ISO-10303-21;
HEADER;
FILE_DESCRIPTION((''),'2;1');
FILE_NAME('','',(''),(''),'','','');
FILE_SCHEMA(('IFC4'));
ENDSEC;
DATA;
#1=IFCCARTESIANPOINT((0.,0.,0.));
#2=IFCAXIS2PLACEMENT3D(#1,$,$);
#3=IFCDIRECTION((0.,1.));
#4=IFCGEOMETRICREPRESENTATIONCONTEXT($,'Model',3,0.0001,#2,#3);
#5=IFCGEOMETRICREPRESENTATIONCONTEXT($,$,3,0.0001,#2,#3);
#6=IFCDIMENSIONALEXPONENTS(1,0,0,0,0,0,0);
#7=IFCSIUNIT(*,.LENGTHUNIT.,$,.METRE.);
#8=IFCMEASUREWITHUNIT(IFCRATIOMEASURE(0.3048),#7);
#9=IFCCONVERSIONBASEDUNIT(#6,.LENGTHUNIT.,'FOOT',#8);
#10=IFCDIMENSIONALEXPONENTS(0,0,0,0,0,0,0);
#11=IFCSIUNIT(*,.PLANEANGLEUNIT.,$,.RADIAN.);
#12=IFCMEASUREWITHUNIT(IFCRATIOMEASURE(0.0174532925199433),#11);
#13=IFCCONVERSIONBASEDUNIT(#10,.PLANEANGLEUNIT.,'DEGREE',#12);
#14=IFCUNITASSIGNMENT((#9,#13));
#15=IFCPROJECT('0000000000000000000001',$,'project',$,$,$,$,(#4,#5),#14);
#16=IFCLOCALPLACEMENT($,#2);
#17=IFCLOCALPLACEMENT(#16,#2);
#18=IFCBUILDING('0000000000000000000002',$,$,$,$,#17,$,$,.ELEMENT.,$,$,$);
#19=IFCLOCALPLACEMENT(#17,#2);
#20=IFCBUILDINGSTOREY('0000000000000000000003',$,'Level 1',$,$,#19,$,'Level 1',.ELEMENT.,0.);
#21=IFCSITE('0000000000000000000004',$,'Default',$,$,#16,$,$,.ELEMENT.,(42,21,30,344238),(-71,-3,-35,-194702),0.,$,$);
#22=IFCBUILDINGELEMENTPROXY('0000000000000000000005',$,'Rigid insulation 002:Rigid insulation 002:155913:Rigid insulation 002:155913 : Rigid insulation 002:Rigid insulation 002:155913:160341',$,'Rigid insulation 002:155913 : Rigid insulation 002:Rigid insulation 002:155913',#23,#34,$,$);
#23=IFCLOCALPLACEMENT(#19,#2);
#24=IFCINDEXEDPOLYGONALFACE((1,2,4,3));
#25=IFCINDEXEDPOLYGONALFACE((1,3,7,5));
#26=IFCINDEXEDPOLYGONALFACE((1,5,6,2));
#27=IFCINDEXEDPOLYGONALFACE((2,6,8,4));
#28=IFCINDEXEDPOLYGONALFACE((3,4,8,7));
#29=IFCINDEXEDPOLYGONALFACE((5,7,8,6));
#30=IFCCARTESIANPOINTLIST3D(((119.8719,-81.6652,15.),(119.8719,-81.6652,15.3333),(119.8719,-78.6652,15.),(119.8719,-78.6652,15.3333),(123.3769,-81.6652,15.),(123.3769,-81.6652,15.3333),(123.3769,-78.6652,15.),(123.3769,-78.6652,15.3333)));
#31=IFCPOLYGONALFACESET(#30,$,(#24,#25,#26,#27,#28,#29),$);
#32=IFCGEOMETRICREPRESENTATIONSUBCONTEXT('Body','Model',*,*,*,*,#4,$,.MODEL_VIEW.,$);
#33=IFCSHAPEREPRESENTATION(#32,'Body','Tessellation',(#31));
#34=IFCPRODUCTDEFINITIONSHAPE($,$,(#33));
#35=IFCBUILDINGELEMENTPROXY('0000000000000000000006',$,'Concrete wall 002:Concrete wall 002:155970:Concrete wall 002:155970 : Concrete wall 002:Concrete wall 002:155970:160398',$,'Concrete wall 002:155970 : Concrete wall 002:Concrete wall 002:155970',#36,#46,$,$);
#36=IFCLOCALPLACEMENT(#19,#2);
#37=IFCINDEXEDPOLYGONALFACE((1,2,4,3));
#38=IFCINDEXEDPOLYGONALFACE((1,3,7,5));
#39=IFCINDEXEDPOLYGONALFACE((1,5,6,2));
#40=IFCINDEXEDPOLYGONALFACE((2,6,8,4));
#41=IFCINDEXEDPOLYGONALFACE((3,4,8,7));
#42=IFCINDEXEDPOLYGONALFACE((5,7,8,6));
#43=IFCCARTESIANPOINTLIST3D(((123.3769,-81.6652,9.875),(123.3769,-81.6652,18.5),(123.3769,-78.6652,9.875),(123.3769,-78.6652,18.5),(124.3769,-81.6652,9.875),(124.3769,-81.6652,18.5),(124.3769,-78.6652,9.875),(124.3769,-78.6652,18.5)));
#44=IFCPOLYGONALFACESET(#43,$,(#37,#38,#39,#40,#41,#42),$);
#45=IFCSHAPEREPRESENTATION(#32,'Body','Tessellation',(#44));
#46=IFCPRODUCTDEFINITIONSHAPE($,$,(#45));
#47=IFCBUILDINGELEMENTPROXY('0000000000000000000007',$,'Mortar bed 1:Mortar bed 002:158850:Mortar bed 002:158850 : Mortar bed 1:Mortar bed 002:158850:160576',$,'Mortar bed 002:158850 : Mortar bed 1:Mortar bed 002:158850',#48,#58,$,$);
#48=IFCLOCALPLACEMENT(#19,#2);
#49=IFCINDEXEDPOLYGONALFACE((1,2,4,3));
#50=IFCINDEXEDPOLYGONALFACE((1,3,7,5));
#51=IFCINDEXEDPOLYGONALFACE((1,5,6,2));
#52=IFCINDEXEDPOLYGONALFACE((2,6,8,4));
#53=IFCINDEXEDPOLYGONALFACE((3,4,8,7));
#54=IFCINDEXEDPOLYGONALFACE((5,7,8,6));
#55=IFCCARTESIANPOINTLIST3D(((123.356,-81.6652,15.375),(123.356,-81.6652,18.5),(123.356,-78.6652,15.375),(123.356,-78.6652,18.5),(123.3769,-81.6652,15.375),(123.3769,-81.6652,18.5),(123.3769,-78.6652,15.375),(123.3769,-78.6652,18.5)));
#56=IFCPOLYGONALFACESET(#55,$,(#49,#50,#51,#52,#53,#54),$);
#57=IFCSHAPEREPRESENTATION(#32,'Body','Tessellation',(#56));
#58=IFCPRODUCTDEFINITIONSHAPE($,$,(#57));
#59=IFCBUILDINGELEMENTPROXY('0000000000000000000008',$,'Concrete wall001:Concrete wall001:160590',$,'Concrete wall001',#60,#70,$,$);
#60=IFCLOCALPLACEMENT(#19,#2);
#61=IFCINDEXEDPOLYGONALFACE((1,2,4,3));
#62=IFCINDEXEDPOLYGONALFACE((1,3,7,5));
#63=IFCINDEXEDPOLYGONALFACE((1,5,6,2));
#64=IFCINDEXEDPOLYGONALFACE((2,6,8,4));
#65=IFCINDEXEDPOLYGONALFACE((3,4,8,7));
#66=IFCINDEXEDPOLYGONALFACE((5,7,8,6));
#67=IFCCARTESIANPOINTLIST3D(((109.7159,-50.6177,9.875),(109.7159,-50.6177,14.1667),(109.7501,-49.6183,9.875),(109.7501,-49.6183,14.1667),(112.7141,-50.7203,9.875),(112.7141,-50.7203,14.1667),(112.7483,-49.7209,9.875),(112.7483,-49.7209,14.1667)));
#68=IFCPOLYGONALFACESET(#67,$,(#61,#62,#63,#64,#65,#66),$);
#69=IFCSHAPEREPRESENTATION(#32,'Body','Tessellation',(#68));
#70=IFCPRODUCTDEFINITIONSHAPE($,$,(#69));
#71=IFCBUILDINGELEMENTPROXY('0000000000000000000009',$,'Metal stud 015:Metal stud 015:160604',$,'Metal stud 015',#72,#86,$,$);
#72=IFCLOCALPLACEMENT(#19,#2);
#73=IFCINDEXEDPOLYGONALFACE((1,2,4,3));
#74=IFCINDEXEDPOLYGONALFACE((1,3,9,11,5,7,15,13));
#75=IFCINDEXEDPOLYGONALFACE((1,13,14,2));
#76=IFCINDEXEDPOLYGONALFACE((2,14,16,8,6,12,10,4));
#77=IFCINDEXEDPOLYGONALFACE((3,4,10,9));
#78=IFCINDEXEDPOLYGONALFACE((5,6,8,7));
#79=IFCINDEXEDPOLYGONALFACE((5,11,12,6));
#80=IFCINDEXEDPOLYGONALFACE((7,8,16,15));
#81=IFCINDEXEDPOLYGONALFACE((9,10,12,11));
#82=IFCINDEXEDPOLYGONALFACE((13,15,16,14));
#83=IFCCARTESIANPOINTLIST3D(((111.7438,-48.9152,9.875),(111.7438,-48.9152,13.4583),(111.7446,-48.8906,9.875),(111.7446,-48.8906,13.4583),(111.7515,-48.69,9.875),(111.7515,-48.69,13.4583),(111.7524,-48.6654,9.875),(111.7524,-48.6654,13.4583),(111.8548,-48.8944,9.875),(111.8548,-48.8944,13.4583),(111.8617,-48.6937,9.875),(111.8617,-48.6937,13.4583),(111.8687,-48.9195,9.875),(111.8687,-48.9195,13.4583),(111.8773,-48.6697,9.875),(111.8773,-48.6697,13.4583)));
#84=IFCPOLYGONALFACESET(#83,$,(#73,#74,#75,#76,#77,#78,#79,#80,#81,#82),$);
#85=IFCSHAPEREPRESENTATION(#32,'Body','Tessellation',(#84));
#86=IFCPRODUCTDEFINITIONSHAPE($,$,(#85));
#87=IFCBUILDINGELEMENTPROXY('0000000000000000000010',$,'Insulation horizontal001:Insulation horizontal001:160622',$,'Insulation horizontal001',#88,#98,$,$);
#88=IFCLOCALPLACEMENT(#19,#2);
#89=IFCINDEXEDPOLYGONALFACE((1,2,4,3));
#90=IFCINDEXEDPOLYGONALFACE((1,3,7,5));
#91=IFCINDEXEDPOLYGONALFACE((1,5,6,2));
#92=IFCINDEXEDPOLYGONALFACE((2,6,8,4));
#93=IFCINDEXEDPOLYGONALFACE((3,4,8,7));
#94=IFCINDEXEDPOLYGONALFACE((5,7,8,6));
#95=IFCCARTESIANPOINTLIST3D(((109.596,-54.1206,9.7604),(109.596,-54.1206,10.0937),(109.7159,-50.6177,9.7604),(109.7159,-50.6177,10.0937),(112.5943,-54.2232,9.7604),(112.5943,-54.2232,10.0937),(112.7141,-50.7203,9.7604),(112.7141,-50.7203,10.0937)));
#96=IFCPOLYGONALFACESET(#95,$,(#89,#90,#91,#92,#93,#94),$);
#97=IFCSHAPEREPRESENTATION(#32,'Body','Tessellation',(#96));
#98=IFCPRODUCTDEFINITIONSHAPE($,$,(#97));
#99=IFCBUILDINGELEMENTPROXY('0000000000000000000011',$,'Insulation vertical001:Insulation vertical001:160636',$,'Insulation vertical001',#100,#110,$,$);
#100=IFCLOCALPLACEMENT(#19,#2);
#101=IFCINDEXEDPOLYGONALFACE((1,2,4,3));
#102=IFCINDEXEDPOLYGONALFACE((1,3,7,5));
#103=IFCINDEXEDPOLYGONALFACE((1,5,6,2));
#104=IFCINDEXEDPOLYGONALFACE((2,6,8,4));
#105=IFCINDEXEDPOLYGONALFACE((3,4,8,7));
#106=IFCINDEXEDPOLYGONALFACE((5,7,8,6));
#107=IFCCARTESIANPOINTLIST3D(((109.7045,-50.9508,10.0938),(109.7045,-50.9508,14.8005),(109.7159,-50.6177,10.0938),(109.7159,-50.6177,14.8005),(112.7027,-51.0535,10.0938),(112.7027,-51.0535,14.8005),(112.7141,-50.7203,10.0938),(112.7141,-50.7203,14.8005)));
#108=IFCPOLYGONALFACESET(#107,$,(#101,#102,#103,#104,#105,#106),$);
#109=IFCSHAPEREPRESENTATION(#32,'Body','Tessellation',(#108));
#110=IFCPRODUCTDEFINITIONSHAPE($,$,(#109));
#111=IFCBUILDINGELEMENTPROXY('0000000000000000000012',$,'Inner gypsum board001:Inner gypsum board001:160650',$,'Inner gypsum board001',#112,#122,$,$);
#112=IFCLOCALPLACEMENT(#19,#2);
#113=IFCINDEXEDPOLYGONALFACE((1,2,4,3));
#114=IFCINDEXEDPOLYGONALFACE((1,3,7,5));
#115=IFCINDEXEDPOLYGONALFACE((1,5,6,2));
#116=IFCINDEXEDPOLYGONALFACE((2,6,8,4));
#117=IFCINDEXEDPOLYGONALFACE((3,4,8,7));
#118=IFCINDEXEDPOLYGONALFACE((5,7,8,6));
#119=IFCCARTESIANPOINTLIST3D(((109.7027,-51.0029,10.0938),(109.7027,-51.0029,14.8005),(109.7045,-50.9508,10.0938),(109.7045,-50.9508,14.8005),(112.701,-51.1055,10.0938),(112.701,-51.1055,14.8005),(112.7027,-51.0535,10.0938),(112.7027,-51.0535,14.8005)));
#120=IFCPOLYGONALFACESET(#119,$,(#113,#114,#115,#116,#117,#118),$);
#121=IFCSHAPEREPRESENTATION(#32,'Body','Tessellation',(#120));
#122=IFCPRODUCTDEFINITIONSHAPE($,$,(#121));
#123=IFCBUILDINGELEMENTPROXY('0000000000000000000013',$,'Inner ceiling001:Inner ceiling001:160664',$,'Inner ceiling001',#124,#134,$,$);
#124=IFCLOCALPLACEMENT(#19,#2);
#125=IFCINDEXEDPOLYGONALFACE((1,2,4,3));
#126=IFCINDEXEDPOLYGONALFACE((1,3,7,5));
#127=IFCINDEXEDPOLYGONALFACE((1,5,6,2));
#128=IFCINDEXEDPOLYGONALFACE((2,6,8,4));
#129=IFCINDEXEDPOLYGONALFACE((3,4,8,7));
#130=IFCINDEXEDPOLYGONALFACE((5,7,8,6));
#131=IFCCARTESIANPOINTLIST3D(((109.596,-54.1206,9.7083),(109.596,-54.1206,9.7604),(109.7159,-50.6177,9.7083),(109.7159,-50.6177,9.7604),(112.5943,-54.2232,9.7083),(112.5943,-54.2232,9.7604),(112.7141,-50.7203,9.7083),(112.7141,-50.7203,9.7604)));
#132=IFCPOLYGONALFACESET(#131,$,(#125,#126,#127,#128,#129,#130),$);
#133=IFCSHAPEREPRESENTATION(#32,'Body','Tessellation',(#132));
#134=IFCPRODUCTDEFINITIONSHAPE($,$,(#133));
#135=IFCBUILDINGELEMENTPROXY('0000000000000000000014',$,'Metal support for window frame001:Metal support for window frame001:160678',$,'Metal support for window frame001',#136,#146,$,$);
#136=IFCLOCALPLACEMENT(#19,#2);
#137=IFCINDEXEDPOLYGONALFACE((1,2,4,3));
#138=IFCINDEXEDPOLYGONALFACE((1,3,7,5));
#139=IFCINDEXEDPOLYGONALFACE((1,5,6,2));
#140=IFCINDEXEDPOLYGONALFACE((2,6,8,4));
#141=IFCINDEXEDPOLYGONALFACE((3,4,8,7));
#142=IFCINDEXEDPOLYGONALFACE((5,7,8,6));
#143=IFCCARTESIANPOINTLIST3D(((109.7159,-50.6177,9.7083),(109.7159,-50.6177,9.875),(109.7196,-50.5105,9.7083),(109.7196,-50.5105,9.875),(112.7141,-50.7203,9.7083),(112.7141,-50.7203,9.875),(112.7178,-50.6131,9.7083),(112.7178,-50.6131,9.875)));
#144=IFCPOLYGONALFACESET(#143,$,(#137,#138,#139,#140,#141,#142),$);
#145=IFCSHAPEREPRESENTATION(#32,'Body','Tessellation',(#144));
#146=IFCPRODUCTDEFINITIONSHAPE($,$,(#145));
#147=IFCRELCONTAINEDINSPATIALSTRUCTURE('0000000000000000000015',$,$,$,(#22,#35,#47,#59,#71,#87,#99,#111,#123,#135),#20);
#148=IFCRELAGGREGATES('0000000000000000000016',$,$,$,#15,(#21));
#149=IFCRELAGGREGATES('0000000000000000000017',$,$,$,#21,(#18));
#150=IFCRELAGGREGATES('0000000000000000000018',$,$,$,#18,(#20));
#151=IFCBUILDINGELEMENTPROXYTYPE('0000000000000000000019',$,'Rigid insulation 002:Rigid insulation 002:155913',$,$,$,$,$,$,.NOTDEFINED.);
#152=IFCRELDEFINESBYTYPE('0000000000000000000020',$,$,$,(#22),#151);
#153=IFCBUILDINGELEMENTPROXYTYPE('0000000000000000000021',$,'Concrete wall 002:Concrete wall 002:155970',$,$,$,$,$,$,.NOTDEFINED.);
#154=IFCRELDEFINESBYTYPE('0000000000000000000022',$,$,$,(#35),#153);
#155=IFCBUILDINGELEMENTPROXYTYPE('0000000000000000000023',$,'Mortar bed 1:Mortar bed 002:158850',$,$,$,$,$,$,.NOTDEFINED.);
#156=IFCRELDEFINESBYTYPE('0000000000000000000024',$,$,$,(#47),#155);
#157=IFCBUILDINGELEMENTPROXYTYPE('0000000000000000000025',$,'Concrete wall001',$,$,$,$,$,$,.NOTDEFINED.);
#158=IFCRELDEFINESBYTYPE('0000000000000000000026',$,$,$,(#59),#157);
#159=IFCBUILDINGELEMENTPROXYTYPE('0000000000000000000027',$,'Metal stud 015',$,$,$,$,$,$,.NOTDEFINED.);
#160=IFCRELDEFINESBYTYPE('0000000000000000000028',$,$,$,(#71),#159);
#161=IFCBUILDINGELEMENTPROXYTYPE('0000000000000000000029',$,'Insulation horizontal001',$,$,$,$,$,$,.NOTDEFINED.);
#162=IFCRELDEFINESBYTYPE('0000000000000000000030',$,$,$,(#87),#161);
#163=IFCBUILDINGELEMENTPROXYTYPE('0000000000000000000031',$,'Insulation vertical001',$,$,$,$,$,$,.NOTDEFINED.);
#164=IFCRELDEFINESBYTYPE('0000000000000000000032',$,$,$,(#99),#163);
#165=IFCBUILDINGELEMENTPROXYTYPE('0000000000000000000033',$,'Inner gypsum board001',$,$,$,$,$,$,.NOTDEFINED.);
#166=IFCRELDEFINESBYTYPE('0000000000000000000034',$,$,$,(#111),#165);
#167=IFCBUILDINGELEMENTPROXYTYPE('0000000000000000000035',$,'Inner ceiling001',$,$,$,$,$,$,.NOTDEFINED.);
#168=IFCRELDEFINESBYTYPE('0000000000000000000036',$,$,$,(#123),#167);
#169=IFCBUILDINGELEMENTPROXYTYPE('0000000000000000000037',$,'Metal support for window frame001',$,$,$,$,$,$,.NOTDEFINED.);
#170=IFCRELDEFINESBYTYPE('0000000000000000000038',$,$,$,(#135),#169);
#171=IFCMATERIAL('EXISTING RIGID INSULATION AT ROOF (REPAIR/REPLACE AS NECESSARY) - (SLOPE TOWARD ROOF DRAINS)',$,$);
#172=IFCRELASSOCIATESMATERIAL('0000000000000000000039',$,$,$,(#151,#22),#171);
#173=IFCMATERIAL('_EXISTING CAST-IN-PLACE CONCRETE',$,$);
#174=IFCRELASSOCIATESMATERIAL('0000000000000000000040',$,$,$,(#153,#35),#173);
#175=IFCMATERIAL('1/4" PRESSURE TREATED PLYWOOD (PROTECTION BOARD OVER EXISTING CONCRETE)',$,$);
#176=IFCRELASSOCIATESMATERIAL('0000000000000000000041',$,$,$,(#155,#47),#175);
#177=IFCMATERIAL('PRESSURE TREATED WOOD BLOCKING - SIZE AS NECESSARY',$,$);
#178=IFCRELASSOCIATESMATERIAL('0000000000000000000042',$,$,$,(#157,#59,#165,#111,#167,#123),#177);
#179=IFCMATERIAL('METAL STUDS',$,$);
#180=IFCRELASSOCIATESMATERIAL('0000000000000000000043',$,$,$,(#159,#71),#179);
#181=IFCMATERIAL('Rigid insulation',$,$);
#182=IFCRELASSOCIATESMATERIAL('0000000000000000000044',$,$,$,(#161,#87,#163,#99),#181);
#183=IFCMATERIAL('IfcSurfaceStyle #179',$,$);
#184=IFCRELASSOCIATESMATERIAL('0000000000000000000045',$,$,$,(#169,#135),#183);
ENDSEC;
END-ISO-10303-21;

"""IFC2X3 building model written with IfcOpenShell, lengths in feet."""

from ifc_helpers import new_model, entity, si_unit, converted_unit, direction, frame, frame_2d, origin, origin_2d_with_axis, place, context, subcontext, project, spatial, polyline, rectangle, outline, extrude, source, transform, mapped, material, type_object, type_shapes, element, save


model = new_model("IFC2X3")

# Units and contexts
model_context = context("Model", 3, precision=0.0001, world=origin(), true_north=direction((0.0, 1.0)))
context_of_model = context(None, 3, precision=0.0001, world=origin(), true_north=direction((0.0, 1.0)))
body_context = subcontext(model_context, "Body", "Model", "MODEL_VIEW")
ifc_project = project(units=[converted_unit("LENGTHUNIT", "FOOT", entity("IfcRatioMeasure", 0.3048), si_unit("LENGTHUNIT", "METRE"), dimensions=[1, 0, 0, 0, 0, 0, 0]), converted_unit("PLANEANGLEUNIT", "DEGREE", entity("IfcRatioMeasure", 0.0174532925199433), si_unit("PLANEANGLEUNIT", "RADIAN"), dimensions=[0, 0, 0, 0, 0, 0, 0])], contexts=[model_context, context_of_model])

# Site, building, storey
site_placement = place(None, origin())
site = spatial("IfcSite", under=ifc_project, at=site_placement, Name="Default", CompositionType="ELEMENT", RefLatitude=(42, 21, 30, 344238), RefLongitude=(-71, -3, -35, -194702), RefElevation=0.0)
building_placement = place(site_placement, origin())
building = spatial("IfcBuilding", under=site, at=building_placement, CompositionType="ELEMENT")
storey_placement = place(building_placement, origin())
storey = spatial("IfcBuildingStorey", under=building, at=storey_placement, Name="Level 1", LongName="Level 1", CompositionType="ELEMENT", Elevation=0.0)

# Building element proxies
ifc_material_1 = material(Name="EXISTING RIGID INSULATION AT ROOF (REPAIR/REPLACE AS NECESSARY) - (SLOPE TOWARD ROOF DRAINS)")
building_element_proxy_type_1 = type_object("IfcBuildingElementProxyType", Name="Rigid insulation 002:Rigid insulation 002:155913", PredefinedType="NOTDEFINED", material=ifc_material_1)
shared_shape_1 = source(origin(), body_context, "Body", "SweptSolid", [
    extrude(rectangle(XDim=3.505, YDim=3.0, at=frame_2d((0.0, 0.0), x_axis=(1.0, 0.0))), frame((121.6244, -80.1652, 15.0), z_axis=(0.0, 0.0, 1.0), x_axis=(-1.0, 0.0, 0.0)), (0.0, 0.0, 1.0), 0.3333),
])
type_shapes(building_element_proxy_type_1, [shared_shape_1])
proxy_1_placement = place(storey_placement, origin())
element("IfcBuildingElementProxy", 1, at=proxy_1_placement, inside=storey, type_object=building_element_proxy_type_1, material=ifc_material_1, Name="Rigid insulation 002:Rigid insulation 002:155913:Rigid insulation 002:155913 : Rigid insulation 002:Rigid insulation 002:155913:160341", ObjectType="Rigid insulation 002:155913 : Rigid insulation 002:Rigid insulation 002:155913", context=body_context, shape_type="MappedRepresentation", body=[
    mapped(shared_shape_1, transform((0.0, 0.0, 0.0), scale=1.0)),
])
ifc_material_2 = material(Name="PRESSURE TREATED WOOD BLOCKING - SIZE AS NECESSARY")
ifc_material_3 = material(Name="_EXISTING CAST-IN-PLACE CONCRETE")
building_element_proxy_type_2 = type_object("IfcBuildingElementProxyType", Name="Concrete wall 002:Concrete wall 002:155970", PredefinedType="NOTDEFINED", material=ifc_material_3)
shared_shape_2 = source(origin(), body_context, "Body", "SweptSolid", [
    extrude(rectangle(XDim=1.0, YDim=3.0, at=frame_2d((0.0, 0.0), x_axis=(1.0, 0.0))), frame((123.8769, -80.1652, 9.875), z_axis=(0.0, 0.0, 1.0), x_axis=(-1.0, 0.0, 0.0)), (0.0, 0.0, 1.0), 8.625),
])
type_shapes(building_element_proxy_type_2, [shared_shape_2])
proxy_2_placement = place(storey_placement, origin())
element("IfcBuildingElementProxy", 2, at=proxy_2_placement, inside=storey, type_object=building_element_proxy_type_2, material=ifc_material_3, Name="Concrete wall 002:Concrete wall 002:155970:Concrete wall 002:155970 : Concrete wall 002:Concrete wall 002:155970:160398", ObjectType="Concrete wall 002:155970 : Concrete wall 002:Concrete wall 002:155970", context=body_context, shape_type="MappedRepresentation", body=[
    mapped(shared_shape_2, transform((0.0, 0.0, 0.0), scale=1.0)),
])
ifc_material_4 = material(Name="1/4\" PRESSURE TREATED PLYWOOD (PROTECTION BOARD OVER EXISTING CONCRETE)")
building_element_proxy_type_3 = type_object("IfcBuildingElementProxyType", Name="Mortar bed 1:Mortar bed 002:158850", PredefinedType="NOTDEFINED", material=ifc_material_4)
shared_shape_3 = source(origin(), body_context, "Body", "SweptSolid", [
    extrude(rectangle(XDim=3.0, YDim=0.0208, at=origin_2d_with_axis()), frame((123.3665, -80.1652, 15.375), z_axis=(0.0, 0.0, 1.0), x_axis=(0.0, 1.0, 0.0)), (0.0, 0.0, 1.0), 3.125),
])
type_shapes(building_element_proxy_type_3, [shared_shape_3])
proxy_3_placement = place(storey_placement, origin())
element("IfcBuildingElementProxy", 3, at=proxy_3_placement, inside=storey, type_object=building_element_proxy_type_3, material=ifc_material_4, Name="Mortar bed 1:Mortar bed 002:158850:Mortar bed 002:158850 : Mortar bed 1:Mortar bed 002:158850:160576", ObjectType="Mortar bed 002:158850 : Mortar bed 1:Mortar bed 002:158850", context=body_context, shape_type="MappedRepresentation", body=[
    mapped(shared_shape_3, transform((0.0, 0.0, 0.0), scale=1.0)),
])
building_element_proxy_type_4 = type_object("IfcBuildingElementProxyType", Name="Concrete wall001", PredefinedType="NOTDEFINED", material=ifc_material_2)
shared_shape_4 = source(origin(), body_context, "Body", "SweptSolid", [
    extrude(rectangle(XDim=3.0, YDim=1.0, at=origin_2d_with_axis()), frame((111.2321, -50.1693, 9.875), z_axis=(0.0, 0.0, 1.0), x_axis=(-0.999415, 0.034202, 0.0)), (0.0, 0.0, 1.0), 4.2917),
])
type_shapes(building_element_proxy_type_4, [shared_shape_4])
proxy_4_placement = place(storey_placement, origin())
element("IfcBuildingElementProxy", 4, at=proxy_4_placement, inside=storey, type_object=building_element_proxy_type_4, material=ifc_material_2, Name="Concrete wall001:Concrete wall001:160590", ObjectType="Concrete wall001", context=body_context, shape_type="MappedRepresentation", body=[
    mapped(shared_shape_4, transform((0.0, 0.0, 0.0), scale=1.0)),
])
ifc_material_5 = material(Name="METAL STUDS")
building_element_proxy_type_5 = type_object("IfcBuildingElementProxyType", Name="Metal stud 015", PredefinedType="NOTDEFINED", material=ifc_material_5)
shared_shape_5 = source(origin(), body_context, "Body", "SweptSolid", [
    extrude(outline(polyline([(-0.0662, -0.125), (0.0588, -0.125), (0.0588, -0.1004), (-0.0514, -0.1004), (-0.0514, 0.1004), (0.0588, 0.1004), (0.0588, 0.125), (-0.0662, 0.125), (-0.0662, -0.125)])), frame((111.8069, -48.7923, 9.875), z_axis=(0.0, 0.0, 1.0), x_axis=(-0.999415, 0.034202, 0.0)), (0.0, 0.0, 1.0), 3.5833),
])
type_shapes(building_element_proxy_type_5, [shared_shape_5])
proxy_5_placement = place(storey_placement, origin())
element("IfcBuildingElementProxy", 5, at=proxy_5_placement, inside=storey, type_object=building_element_proxy_type_5, material=ifc_material_5, Name="Metal stud 015:Metal stud 015:160604", ObjectType="Metal stud 015", context=body_context, shape_type="MappedRepresentation", body=[
    mapped(shared_shape_5, transform((0.0, 0.0, 0.0), scale=1.0)),
])
ifc_material_6 = material(Name="Rigid insulation")
building_element_proxy_type_6 = type_object("IfcBuildingElementProxyType", Name="Insulation horizontal001", PredefinedType="NOTDEFINED", material=ifc_material_6)
shared_shape_6 = source(origin(), body_context, "Body", "SweptSolid", [
    extrude(rectangle(XDim=3.0, YDim=3.505, at=frame_2d((0.0, 0.0), x_axis=(1.0, 0.0))), frame((111.1551, -52.4205, 9.7604), z_axis=(0.0, 0.0, 1.0), x_axis=(-0.999415, 0.034202, 0.0)), (0.0, 0.0, 1.0), 0.3333),
])
type_shapes(building_element_proxy_type_6, [shared_shape_6])
proxy_6_placement = place(storey_placement, origin())
element("IfcBuildingElementProxy", 6, at=proxy_6_placement, inside=storey, type_object=building_element_proxy_type_6, material=ifc_material_6, Name="Insulation horizontal001:Insulation horizontal001:160622", ObjectType="Insulation horizontal001", context=body_context, shape_type="MappedRepresentation", body=[
    mapped(shared_shape_6, transform((0.0, 0.0, 0.0), scale=1.0)),
])
building_element_proxy_type_7 = type_object("IfcBuildingElementProxyType", Name="Insulation vertical001", PredefinedType="NOTDEFINED", material=ifc_material_6)
shared_shape_7 = source(origin(), body_context, "Body", "SweptSolid", [
    extrude(rectangle(XDim=3.0, YDim=0.3333, at=frame_2d((0.0, 0.0), x_axis=(1.0, 0.0))), frame((111.2093, -50.8356, 10.0938), z_axis=(0.0, 0.0, 1.0), x_axis=(-0.999415, 0.034202, 0.0)), (0.0, 0.0, 1.0), 4.7068),
])
type_shapes(building_element_proxy_type_7, [shared_shape_7])
proxy_7_placement = place(storey_placement, origin())
element("IfcBuildingElementProxy", 7, at=proxy_7_placement, inside=storey, type_object=building_element_proxy_type_7, material=ifc_material_6, Name="Insulation vertical001:Insulation vertical001:160636", ObjectType="Insulation vertical001", context=body_context, shape_type="MappedRepresentation", body=[
    mapped(shared_shape_7, transform((0.0, 0.0, 0.0), scale=1.0)),
])
building_element_proxy_type_8 = type_object("IfcBuildingElementProxyType", Name="Inner gypsum board001", PredefinedType="NOTDEFINED", material=ifc_material_2)
shared_shape_8 = source(origin(), body_context, "Body", "SweptSolid", [
    extrude(rectangle(XDim=3.0, YDim=0.0521, at=frame_2d((0.0, 0.0), x_axis=(1.0, 0.0))), frame((111.2027, -51.0282, 10.0938), z_axis=(0.0, 0.0, 1.0), x_axis=(-0.999415, 0.034202, 0.0)), (0.0, 0.0, 1.0), 4.7068),
])
type_shapes(building_element_proxy_type_8, [shared_shape_8])
proxy_8_placement = place(storey_placement, origin())
element("IfcBuildingElementProxy", 8, at=proxy_8_placement, inside=storey, type_object=building_element_proxy_type_8, material=ifc_material_2, Name="Inner gypsum board001:Inner gypsum board001:160650", ObjectType="Inner gypsum board001", context=body_context, shape_type="MappedRepresentation", body=[
    mapped(shared_shape_8, transform((0.0, 0.0, 0.0), scale=1.0)),
])
building_element_proxy_type_9 = type_object("IfcBuildingElementProxyType", Name="Inner ceiling001", PredefinedType="NOTDEFINED", material=ifc_material_2)
shared_shape_9 = source(origin(), body_context, "Body", "SweptSolid", [
    extrude(rectangle(XDim=3.0, YDim=3.505, at=frame_2d((0.0, 0.0), x_axis=(1.0, 0.0))), frame((111.1551, -52.4205, 9.7083), z_axis=(0.0, 0.0, 1.0), x_axis=(-0.999415, 0.034202, 0.0)), (0.0, 0.0, 1.0), 0.0521),
])
type_shapes(building_element_proxy_type_9, [shared_shape_9])
proxy_9_placement = place(storey_placement, origin())
element("IfcBuildingElementProxy", 9, at=proxy_9_placement, inside=storey, type_object=building_element_proxy_type_9, material=ifc_material_2, Name="Inner ceiling001:Inner ceiling001:160664", ObjectType="Inner ceiling001", context=body_context, shape_type="MappedRepresentation", body=[
    mapped(shared_shape_9, transform((0.0, 0.0, 0.0), scale=1.0)),
])
ifc_material_7 = material(Name="IfcSurfaceStyle #179")
building_element_proxy_type_10 = type_object("IfcBuildingElementProxyType", Name="Metal support for window frame001", PredefinedType="NOTDEFINED", material=ifc_material_7)
shared_shape_10 = source(origin(), body_context, "Body", "SweptSolid", [
    extrude(rectangle(XDim=3.0, YDim=0.1073, at=frame_2d((0.0, 0.0), x_axis=(1.0, 0.0))), frame((111.2168, -50.6154, 9.7083), z_axis=(0.0, 0.0, 1.0), x_axis=(-0.999415, 0.034202, 0.0)), (0.0, 0.0, 1.0), 0.1667),
])
type_shapes(building_element_proxy_type_10, [shared_shape_10])
proxy_10_placement = place(storey_placement, origin())
element("IfcBuildingElementProxy", 10, at=proxy_10_placement, inside=storey, type_object=building_element_proxy_type_10, material=ifc_material_7, Name="Metal support for window frame001:Metal support for window frame001:160678", ObjectType="Metal support for window frame001", context=body_context, shape_type="MappedRepresentation", body=[
    mapped(shared_shape_10, transform((0.0, 0.0, 0.0), scale=1.0)),
])

save(model, "model.ifc")
